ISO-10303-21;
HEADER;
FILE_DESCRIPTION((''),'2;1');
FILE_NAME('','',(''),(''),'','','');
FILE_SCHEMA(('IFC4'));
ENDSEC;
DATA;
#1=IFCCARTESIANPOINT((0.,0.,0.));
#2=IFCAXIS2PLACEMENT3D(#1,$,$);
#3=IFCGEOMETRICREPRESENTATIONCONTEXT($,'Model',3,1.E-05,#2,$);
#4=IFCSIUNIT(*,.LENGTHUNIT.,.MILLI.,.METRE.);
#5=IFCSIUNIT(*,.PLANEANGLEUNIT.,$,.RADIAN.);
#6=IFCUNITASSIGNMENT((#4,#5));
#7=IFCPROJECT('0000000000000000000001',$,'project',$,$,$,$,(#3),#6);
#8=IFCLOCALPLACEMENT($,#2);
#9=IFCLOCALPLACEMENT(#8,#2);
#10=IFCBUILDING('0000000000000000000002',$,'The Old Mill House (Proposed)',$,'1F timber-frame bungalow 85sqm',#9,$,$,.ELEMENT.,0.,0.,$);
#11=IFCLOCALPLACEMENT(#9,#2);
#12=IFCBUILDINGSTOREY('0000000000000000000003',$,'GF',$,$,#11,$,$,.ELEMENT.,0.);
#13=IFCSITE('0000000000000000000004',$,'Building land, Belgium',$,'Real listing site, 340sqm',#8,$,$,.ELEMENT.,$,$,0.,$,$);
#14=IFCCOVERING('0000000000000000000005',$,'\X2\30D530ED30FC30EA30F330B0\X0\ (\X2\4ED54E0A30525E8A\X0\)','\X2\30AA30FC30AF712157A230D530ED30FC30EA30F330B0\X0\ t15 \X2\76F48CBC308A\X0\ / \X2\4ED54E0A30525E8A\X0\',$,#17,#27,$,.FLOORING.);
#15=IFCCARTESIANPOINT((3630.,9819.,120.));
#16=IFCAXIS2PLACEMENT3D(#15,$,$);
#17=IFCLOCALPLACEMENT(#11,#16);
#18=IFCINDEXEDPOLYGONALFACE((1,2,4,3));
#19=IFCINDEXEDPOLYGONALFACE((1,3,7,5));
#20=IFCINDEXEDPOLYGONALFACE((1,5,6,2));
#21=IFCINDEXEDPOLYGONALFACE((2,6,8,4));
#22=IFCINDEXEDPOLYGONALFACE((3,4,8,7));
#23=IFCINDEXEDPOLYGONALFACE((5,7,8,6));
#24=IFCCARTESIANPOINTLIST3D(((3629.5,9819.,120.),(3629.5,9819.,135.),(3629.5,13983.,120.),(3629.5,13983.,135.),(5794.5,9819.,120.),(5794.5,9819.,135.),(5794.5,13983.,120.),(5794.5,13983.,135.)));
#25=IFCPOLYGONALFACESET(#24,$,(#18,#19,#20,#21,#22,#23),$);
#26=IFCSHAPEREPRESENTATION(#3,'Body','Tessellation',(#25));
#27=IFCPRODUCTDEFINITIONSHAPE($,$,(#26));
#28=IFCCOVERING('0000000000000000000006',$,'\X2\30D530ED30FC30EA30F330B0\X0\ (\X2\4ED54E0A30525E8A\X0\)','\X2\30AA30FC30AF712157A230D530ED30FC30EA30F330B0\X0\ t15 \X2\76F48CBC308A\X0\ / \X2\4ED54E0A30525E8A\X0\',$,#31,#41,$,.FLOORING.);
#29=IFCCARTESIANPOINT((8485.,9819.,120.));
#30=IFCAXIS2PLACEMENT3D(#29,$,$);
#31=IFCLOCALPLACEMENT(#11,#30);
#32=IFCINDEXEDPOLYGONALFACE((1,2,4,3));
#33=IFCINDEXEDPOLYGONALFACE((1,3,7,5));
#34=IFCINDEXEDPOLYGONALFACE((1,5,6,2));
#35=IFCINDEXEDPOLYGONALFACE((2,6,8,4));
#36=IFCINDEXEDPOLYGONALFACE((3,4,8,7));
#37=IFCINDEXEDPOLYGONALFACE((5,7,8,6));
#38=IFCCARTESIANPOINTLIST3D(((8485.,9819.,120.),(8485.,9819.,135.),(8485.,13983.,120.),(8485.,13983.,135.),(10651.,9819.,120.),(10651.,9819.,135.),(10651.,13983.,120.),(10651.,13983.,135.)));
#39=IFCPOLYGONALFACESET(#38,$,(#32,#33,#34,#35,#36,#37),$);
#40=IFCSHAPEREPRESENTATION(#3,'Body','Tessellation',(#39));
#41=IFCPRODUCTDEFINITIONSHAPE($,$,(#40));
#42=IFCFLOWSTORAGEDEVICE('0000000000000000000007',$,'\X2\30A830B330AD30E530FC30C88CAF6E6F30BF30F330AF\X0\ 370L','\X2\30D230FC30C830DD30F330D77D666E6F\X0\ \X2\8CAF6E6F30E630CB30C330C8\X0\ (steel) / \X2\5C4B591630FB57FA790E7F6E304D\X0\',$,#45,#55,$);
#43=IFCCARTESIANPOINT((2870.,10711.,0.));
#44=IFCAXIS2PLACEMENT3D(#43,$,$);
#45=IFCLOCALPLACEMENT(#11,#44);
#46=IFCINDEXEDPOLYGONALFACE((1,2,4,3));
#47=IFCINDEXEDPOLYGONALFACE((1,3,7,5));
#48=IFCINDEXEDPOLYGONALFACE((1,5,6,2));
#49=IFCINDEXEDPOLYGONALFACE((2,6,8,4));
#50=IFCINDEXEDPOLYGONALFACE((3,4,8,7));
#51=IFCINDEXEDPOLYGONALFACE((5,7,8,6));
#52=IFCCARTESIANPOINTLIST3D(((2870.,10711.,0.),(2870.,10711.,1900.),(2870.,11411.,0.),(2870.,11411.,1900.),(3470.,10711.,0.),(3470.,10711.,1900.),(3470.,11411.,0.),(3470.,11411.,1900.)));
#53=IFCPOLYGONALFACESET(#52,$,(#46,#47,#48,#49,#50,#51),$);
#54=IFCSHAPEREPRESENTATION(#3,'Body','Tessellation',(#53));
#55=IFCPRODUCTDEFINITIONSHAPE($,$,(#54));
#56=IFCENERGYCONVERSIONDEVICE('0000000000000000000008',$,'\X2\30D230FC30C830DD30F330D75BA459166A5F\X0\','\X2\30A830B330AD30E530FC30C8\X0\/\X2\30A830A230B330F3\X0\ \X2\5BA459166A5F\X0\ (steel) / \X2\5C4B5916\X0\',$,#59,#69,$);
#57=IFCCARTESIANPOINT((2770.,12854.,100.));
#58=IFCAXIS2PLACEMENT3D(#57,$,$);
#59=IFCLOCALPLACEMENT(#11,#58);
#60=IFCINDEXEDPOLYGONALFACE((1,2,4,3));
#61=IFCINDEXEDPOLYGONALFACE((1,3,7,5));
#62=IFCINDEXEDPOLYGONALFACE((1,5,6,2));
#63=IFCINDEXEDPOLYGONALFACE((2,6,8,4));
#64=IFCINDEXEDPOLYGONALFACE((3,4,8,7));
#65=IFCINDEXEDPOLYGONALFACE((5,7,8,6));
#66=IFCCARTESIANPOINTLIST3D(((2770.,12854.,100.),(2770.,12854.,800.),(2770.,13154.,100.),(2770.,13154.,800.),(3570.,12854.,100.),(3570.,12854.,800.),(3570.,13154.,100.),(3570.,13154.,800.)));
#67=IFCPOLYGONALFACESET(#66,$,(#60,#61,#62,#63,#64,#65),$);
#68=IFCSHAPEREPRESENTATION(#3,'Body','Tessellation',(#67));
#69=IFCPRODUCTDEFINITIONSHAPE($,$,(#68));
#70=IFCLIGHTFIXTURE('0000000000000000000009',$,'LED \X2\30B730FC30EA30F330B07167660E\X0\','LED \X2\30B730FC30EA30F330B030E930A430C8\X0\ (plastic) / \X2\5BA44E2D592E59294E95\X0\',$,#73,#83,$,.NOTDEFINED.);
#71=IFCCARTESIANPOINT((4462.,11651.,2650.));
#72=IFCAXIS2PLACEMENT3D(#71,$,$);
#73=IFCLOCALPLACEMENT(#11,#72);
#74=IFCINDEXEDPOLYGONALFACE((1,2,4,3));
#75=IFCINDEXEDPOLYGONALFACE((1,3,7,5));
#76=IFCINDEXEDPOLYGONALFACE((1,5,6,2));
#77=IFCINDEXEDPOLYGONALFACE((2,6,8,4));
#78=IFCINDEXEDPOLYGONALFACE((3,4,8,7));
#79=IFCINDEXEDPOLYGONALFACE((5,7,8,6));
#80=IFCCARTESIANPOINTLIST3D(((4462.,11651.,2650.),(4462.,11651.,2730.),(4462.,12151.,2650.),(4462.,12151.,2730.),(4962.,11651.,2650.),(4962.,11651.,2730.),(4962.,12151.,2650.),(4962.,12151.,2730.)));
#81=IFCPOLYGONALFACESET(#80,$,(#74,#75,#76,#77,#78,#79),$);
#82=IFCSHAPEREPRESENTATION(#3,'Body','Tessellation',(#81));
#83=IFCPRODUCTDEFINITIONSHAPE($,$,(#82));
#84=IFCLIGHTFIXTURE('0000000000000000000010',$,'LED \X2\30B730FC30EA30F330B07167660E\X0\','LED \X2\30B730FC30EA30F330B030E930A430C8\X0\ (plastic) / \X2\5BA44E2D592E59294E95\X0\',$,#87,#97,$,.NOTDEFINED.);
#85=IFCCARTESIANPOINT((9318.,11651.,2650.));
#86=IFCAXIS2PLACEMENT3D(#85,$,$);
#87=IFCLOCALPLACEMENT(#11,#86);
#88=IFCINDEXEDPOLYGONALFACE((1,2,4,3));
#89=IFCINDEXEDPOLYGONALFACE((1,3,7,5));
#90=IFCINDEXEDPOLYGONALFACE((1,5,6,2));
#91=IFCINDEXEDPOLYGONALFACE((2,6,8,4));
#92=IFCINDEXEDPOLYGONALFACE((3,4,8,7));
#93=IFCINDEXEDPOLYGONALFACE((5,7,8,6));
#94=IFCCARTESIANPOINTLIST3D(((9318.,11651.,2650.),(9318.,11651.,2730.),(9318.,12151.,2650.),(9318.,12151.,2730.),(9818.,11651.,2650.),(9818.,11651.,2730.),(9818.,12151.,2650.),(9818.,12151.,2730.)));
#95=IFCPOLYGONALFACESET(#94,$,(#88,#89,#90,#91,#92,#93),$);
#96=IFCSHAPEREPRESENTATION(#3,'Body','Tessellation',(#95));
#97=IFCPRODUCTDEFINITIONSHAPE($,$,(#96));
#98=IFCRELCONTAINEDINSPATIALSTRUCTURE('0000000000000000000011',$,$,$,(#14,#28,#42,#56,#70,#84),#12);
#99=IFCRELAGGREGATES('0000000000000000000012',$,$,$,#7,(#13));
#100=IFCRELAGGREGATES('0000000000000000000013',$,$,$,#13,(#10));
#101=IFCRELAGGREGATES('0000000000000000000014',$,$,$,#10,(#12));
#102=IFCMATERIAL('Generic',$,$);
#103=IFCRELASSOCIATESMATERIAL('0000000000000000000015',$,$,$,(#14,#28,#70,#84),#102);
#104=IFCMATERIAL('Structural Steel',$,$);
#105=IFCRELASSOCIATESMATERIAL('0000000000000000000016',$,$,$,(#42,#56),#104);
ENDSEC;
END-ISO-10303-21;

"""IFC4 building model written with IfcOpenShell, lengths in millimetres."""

from ifc_helpers import new_model, si_unit, frame, frame_2d, origin, place, context, project, spatial, rectangle, extrude, material, element, save


model = new_model("IFC4")

# Units and contexts
model_context = context("Model", 3, precision=1e-05, world=origin())
ifc_project = project(units=[si_unit("LENGTHUNIT", "METRE", prefix="MILLI"), si_unit("PLANEANGLEUNIT", "RADIAN")], contexts=[model_context])

# Site, building, storey
site_placement = place(None, origin())
site = spatial("IfcSite", under=ifc_project, at=site_placement, Name="Building land, Belgium", ObjectType="Real listing site, 340sqm", CompositionType="ELEMENT", RefElevation=0.0)
building_placement = place(site_placement, origin())
building = spatial("IfcBuilding", under=site, at=building_placement, Name="The Old Mill House (Proposed)", ObjectType="1F timber-frame bungalow 85sqm", CompositionType="ELEMENT", ElevationOfRefHeight=0.0, ElevationOfTerrain=0.0)
storey_placement = place(building_placement, origin())
storey = spatial("IfcBuildingStorey", under=building, at=storey_placement, Name="GF", CompositionType="ELEMENT", Elevation=0.0)

# Shared definitions
ifc_material_1 = material(Name="Structural Steel")

# Coverings
ifc_material_2 = material(Name="Generic")
covering_1_placement = place(storey_placement, frame((3630.0, 9819.0, 120.0)))
element("IfcCovering", 1, at=covering_1_placement, inside=storey, material=ifc_material_2, Name="フローリング (仕上げ床)", Description="オーク無垢フローリング t15 直貼り / 仕上げ床", PredefinedType="FLOORING", context=model_context, shape_type="SweptSolid", body=[
    extrude(rectangle(XDim=2165.0, YDim=4164.0, at=frame_2d((1082.0, 2082.0))), frame((3630.0, 9819.0, 120.0)), (0.0, 0.0, 1.0), 15.0),
])
covering_2_placement = place(storey_placement, frame((8485.0, 9819.0, 120.0)))
element("IfcCovering", 2, at=covering_2_placement, inside=storey, material=ifc_material_2, Name="フローリング (仕上げ床)", Description="オーク無垢フローリング t15 直貼り / 仕上げ床", PredefinedType="FLOORING", context=model_context, shape_type="SweptSolid", body=[
    extrude(rectangle(XDim=2166.0, YDim=4164.0, at=frame_2d((1083.0, 2082.0))), frame((8485.0, 9819.0, 120.0)), (0.0, 0.0, 1.0), 15.0),
])

# Flow storage device
flow_storage_device_placement = place(storey_placement, frame((2870.0, 10711.0, 0.0)))
element("IfcFlowStorageDevice", 3, at=flow_storage_device_placement, inside=storey, material=ifc_material_1, Name="エコキュート貯湯タンク 370L", Description="ヒートポンプ給湯 貯湯ユニット (steel) / 屋外・基礎置き", context=model_context, shape_type="SweptSolid", body=[
    extrude(rectangle(XDim=600.0, YDim=700.0, at=frame_2d((300.0, 350.0))), frame((2870.0, 10711.0, 0.0)), (0.0, 0.0, 1.0), 1900.0),
])

# Energy conversion device
energy_conversion_device_placement = place(storey_placement, frame((2770.0, 12854.0, 100.0)))
element("IfcEnergyConversionDevice", 4, at=energy_conversion_device_placement, inside=storey, material=ifc_material_1, Name="ヒートポンプ室外機", Description="エコキュート/エアコン 室外機 (steel) / 屋外", context=model_context, shape_type="SweptSolid", body=[
    extrude(rectangle(XDim=800.0, YDim=300.0, at=frame_2d((400.0, 150.0))), frame((2770.0, 12854.0, 100.0)), (0.0, 0.0, 1.0), 700.0),
])

# Light fixtures
light_fixture_1_placement = place(storey_placement, frame((4462.0, 11651.0, 2650.0)))
element("IfcLightFixture", 5, at=light_fixture_1_placement, inside=storey, material=ifc_material_2, Name="LED シーリング照明", Description="LED シーリングライト (plastic) / 室中央天井", PredefinedType="NOTDEFINED", context=model_context, shape_type="SweptSolid", body=[
    extrude(rectangle(XDim=500.0, YDim=500.0, at=frame_2d((250.0, 250.0))), frame((4462.0, 11651.0, 2650.0)), (0.0, 0.0, 1.0), 80.0),
])
light_fixture_2_placement = place(storey_placement, frame((9318.0, 11651.0, 2650.0)))
element("IfcLightFixture", 6, at=light_fixture_2_placement, inside=storey, material=ifc_material_2, Name="LED シーリング照明", Description="LED シーリングライト (plastic) / 室中央天井", PredefinedType="NOTDEFINED", context=model_context, shape_type="SweptSolid", body=[
    extrude(rectangle(XDim=500.0, YDim=500.0, at=frame_2d((250.0, 250.0))), frame((9318.0, 11651.0, 2650.0)), (0.0, 0.0, 1.0), 80.0),
])

save(model, "model.ifc")
